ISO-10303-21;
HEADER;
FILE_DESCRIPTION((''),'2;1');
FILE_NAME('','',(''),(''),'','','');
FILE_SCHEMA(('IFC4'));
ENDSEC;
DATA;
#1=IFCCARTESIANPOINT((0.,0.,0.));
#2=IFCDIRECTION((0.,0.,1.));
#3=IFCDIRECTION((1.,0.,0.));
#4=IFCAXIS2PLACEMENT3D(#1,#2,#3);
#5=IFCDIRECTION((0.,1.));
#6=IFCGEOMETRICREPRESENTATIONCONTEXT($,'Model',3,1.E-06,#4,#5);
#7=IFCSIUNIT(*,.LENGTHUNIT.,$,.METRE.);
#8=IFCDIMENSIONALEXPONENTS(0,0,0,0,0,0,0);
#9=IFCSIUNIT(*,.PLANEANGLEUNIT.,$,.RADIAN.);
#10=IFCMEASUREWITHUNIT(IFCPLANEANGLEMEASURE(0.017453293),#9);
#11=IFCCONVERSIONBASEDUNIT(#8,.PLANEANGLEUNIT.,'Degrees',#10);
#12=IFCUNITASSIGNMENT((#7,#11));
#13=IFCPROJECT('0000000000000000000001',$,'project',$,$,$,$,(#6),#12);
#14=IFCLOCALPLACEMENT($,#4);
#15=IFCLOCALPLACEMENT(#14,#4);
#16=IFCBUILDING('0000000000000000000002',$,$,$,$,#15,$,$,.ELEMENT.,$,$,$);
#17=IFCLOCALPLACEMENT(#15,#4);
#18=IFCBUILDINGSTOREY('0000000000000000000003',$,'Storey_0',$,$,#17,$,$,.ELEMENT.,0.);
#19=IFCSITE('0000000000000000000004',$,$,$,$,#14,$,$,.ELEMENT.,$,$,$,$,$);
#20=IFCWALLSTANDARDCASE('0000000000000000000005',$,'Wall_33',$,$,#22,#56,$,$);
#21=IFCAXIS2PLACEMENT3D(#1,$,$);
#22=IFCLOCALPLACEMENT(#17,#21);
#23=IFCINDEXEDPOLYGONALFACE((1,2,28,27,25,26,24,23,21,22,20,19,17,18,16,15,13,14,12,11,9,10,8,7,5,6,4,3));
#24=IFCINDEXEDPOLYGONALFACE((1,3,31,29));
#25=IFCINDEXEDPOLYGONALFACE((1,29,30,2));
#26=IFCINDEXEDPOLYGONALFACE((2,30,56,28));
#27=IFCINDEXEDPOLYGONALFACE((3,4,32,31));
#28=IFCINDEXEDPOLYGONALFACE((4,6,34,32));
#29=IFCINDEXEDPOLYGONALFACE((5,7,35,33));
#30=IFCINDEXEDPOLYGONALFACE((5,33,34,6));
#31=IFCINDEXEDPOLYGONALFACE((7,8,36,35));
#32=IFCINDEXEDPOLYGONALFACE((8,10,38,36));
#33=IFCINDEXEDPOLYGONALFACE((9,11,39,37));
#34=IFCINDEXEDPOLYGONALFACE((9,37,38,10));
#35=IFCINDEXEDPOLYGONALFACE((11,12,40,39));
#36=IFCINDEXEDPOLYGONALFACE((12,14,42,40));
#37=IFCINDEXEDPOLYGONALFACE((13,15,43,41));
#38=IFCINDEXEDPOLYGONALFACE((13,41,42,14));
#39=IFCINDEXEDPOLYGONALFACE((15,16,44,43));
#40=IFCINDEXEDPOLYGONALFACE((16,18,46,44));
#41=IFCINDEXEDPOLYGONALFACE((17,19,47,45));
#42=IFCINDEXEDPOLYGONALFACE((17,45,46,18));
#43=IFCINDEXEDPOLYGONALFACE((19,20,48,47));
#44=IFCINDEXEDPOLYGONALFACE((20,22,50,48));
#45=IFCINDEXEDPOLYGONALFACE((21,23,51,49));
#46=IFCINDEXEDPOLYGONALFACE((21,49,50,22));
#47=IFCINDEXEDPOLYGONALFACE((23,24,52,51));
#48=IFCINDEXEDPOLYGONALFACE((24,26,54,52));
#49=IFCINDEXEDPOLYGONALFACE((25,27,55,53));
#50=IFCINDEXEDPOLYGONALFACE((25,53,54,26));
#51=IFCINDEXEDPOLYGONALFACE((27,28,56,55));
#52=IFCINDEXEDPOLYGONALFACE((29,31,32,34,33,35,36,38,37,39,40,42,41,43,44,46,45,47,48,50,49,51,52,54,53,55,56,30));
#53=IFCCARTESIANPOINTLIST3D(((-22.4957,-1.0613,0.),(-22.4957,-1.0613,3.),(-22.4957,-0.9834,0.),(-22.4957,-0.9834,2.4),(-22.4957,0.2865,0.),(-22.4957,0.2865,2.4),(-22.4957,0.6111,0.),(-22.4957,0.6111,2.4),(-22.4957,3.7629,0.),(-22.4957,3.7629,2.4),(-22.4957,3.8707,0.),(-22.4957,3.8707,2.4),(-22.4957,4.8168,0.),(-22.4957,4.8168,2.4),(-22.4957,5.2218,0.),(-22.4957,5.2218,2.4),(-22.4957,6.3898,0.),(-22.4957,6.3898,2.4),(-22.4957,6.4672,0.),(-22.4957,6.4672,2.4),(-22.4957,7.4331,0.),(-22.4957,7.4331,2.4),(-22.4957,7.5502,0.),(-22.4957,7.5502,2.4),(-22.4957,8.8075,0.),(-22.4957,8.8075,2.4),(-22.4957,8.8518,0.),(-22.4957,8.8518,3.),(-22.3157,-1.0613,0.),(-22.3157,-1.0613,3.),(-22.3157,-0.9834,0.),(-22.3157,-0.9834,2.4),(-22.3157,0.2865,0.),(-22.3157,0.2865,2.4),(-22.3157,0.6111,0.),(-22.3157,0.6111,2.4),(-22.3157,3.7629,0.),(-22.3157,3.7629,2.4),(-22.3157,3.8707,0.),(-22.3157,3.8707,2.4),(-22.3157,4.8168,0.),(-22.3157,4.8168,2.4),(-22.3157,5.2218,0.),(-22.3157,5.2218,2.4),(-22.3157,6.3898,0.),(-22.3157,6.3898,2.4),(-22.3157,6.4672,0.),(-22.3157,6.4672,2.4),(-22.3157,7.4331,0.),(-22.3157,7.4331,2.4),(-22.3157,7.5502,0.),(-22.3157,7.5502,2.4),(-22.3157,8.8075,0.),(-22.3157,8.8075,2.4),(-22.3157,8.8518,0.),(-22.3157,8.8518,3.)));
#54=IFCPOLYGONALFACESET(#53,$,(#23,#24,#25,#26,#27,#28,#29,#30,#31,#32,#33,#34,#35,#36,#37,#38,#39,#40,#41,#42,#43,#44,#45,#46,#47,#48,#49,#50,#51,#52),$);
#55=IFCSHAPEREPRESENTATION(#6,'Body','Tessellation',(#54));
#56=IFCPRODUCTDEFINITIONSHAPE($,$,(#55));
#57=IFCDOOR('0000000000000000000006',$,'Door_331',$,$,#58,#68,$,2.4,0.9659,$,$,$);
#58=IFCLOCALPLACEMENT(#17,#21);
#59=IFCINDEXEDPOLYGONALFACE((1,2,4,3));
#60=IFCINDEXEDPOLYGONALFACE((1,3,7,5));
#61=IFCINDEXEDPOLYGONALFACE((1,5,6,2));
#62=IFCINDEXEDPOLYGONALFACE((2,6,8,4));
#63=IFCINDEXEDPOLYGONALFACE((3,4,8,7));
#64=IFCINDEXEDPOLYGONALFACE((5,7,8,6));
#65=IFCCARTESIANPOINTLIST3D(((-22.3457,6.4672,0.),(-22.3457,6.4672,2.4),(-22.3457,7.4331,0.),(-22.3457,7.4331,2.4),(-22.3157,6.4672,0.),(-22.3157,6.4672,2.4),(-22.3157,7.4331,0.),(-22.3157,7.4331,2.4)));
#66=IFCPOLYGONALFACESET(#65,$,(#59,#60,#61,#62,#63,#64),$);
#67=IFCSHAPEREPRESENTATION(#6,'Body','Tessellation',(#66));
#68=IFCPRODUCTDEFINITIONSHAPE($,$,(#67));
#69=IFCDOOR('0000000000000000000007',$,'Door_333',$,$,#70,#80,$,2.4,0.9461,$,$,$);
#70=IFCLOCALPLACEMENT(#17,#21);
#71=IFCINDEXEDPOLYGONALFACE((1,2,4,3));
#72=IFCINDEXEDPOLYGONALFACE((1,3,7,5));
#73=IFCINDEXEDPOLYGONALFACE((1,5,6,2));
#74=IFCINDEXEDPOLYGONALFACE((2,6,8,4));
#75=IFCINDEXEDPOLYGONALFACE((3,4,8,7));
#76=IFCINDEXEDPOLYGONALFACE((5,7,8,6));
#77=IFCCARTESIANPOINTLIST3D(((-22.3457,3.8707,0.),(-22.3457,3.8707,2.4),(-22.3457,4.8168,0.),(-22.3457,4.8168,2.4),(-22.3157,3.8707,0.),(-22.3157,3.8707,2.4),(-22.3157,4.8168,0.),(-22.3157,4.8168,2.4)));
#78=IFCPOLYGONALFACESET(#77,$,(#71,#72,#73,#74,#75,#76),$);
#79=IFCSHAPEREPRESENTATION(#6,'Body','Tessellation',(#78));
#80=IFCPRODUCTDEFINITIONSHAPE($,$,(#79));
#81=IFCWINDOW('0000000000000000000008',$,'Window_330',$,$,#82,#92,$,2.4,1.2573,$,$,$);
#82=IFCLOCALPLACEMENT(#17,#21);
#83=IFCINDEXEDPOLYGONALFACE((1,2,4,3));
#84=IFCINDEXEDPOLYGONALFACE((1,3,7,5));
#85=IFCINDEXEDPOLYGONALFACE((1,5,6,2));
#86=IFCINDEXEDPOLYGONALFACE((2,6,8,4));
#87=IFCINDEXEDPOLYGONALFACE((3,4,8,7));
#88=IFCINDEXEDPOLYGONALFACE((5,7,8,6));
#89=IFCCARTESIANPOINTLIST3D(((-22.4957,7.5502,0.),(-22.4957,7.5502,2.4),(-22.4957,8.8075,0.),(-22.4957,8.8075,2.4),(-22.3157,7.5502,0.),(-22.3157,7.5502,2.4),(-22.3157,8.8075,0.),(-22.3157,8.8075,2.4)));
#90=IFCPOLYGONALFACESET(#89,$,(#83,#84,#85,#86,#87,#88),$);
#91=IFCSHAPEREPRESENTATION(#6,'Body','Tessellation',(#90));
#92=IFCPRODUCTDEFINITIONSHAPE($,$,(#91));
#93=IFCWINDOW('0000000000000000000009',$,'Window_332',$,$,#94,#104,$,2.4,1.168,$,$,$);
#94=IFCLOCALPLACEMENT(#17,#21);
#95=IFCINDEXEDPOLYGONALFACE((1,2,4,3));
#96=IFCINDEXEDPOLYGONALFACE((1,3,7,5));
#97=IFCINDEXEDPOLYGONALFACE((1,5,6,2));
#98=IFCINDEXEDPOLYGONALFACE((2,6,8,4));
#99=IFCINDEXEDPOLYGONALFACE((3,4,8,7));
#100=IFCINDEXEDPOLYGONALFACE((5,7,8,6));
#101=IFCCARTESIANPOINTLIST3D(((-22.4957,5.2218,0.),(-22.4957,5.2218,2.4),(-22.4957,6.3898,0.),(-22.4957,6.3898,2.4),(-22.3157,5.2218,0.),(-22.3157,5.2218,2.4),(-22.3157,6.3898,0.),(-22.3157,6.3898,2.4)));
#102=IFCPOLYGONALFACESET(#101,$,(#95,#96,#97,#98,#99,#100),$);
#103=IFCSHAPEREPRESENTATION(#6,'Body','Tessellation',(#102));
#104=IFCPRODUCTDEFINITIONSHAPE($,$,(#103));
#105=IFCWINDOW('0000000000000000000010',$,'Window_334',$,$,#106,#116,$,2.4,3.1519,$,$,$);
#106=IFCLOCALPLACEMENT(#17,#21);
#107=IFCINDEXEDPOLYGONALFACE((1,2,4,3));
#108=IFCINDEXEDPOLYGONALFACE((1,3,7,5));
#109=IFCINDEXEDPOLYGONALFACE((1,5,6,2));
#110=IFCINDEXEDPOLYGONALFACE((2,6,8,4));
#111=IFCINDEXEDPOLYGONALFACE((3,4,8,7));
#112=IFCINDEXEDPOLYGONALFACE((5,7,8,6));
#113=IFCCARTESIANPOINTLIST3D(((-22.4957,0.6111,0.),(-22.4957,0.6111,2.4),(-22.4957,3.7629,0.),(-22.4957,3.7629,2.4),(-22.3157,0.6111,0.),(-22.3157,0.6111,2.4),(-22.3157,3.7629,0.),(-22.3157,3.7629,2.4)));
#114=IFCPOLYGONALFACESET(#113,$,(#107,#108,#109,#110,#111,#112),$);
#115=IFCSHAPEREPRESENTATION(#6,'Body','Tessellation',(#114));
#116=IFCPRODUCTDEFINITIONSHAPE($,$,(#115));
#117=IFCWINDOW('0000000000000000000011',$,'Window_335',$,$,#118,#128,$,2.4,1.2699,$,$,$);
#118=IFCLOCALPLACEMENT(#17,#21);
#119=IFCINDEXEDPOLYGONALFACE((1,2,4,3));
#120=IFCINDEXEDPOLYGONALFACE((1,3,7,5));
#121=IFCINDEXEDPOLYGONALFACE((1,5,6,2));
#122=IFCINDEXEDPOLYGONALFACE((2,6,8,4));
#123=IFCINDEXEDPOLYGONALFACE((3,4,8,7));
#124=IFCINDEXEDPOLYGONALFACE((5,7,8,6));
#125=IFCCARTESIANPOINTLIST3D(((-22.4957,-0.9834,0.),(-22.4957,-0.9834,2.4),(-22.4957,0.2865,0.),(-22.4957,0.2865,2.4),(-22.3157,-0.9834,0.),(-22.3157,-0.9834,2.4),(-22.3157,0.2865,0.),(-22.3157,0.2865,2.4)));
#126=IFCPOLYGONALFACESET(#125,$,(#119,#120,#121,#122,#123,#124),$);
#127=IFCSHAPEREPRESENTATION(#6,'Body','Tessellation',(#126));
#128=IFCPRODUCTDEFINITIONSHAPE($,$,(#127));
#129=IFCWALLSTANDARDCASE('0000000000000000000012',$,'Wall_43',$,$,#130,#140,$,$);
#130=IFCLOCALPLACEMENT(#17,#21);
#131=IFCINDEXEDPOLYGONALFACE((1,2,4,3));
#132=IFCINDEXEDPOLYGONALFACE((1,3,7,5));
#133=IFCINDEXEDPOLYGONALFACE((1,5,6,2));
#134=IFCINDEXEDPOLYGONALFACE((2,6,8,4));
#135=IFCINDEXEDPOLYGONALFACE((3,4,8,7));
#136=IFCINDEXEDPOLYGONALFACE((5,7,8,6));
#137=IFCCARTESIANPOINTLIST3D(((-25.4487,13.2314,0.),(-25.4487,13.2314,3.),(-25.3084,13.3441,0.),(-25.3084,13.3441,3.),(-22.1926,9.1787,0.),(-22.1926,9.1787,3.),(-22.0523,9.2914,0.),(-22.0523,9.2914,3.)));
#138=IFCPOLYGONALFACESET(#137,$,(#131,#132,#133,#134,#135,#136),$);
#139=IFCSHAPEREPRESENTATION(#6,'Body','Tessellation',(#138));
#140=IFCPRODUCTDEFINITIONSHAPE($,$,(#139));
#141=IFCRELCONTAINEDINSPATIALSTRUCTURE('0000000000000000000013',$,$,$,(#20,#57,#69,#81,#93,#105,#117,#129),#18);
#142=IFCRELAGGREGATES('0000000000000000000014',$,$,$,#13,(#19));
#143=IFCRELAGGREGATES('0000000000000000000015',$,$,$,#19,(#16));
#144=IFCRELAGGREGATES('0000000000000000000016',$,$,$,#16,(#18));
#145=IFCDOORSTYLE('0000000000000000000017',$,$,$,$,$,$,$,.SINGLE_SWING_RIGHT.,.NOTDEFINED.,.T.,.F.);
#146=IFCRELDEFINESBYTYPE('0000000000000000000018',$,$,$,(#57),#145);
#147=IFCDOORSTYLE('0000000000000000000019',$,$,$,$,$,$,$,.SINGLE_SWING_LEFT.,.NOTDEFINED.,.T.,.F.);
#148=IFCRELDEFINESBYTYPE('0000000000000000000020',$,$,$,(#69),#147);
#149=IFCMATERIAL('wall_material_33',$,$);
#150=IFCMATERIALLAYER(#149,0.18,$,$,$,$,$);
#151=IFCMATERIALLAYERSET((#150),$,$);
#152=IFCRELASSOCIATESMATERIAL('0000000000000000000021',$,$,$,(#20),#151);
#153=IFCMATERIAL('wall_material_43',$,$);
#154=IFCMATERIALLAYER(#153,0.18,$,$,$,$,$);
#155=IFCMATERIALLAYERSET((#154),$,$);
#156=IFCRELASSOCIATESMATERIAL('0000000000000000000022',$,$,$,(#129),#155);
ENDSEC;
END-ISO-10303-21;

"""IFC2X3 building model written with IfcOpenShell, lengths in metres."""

from ifc_helpers import new_model, entity, si_unit, converted_unit, direction, frame, frame_2d, origin_with_axes, place, context, project, spatial, polyline, rectangle, outline, extrude, material, layer, layer_set, layer_usage, type_object, element, fill, save


model = new_model("IFC2X3")

# Units and contexts
model_context = context("Model", 3, precision=1e-06, world=origin_with_axes(), true_north=direction((0.0, 1.0)))
ifc_project = project(units=[si_unit("LENGTHUNIT", "METRE"), converted_unit("PLANEANGLEUNIT", "Degrees", entity("IfcPlaneAngleMeasure", 0.017453293), si_unit("PLANEANGLEUNIT", "RADIAN"), dimensions=[0, 0, 0, 0, 0, 0, 0])], contexts=[model_context])

# Site, building, storey
site_placement = place(None, origin_with_axes())
site = spatial("IfcSite", under=ifc_project, at=site_placement, CompositionType="ELEMENT")
building_placement = place(site_placement, origin_with_axes())
building = spatial("IfcBuilding", under=site, at=building_placement, CompositionType="ELEMENT")
storey_placement = place(building_placement, origin_with_axes())
storey = spatial("IfcBuildingStorey", under=building, at=storey_placement, Name="Storey_0", CompositionType="ELEMENT", Elevation=0.0)

# Wall, openings, doors, windows
ifc_material_1 = material(Name="wall_material_33")
ifc_layer_1 = layer(ifc_material_1, 0.18)
ifc_layer_set_1 = layer_set([ifc_layer_1])
ifc_layer_usage_1 = layer_usage(ifc_layer_set_1, "AXIS2", "NEGATIVE", 0.0)
wall_1_placement = place(storey_placement, frame((-22.3157, 8.8518, 0.0), z_axis=(0.0, 0.0, 1.0), x_axis=(0.0, -1.0, 0.0)))
wall_1 = element("IfcWallStandardCase", 1, at=wall_1_placement, inside=storey, material=ifc_layer_usage_1, Name="Wall_33", context=model_context, shape_type="SweptSolid", body=[
    extrude(outline(polyline([(0.0, 0.0), (9.913, 0.0), (9.913, -0.18), (0.0, -0.18), (0.0, 0.0)])), origin_with_axes(), (0.0, 0.0, 1.0), 3.0),
])
opening_1_placement = place(wall_1_placement, frame((0.0443, 0.0, 0.0), z_axis=(0.0, 0.0, 1.0), x_axis=(1.0, 0.0, 0.0)))
opening_1 = element("IfcOpeningElement", 2, at=opening_1_placement, cuts=wall_1, context=model_context, shape_type="SweptSolid", body=[
    extrude(rectangle(XDim=1.2573, YDim=2.4, at=frame_2d((1.2, -0.6287), x_axis=(0.0, 1.0))), frame((0.0, 0.01, 0.0), z_axis=(0.0, -1.0, 0.0), x_axis=(0.0, 0.0, 1.0)), (0.0, 0.0, 1.0), 0.2),
])
opening_2_placement = place(wall_1_placement, frame((1.4187, 0.0, 0.0), z_axis=(0.0, 0.0, 1.0), x_axis=(1.0, 0.0, 0.0)))
opening_2 = element("IfcOpeningElement", 3, at=opening_2_placement, cuts=wall_1, context=model_context, shape_type="SweptSolid", body=[
    extrude(rectangle(XDim=0.9659, YDim=2.4, at=frame_2d((1.2, -0.4829), x_axis=(0.0, 1.0))), frame((0.0, 0.01, 0.0), z_axis=(0.0, -1.0, 0.0), x_axis=(0.0, 0.0, 1.0)), (0.0, 0.0, 1.0), 0.2),
])
opening_3_placement = place(wall_1_placement, frame((2.462, 0.0, 0.0), z_axis=(0.0, 0.0, 1.0), x_axis=(1.0, 0.0, 0.0)))
opening_3 = element("IfcOpeningElement", 4, at=opening_3_placement, cuts=wall_1, context=model_context, shape_type="SweptSolid", body=[
    extrude(rectangle(XDim=1.168, YDim=2.4, at=frame_2d((1.2, -0.584), x_axis=(0.0, 1.0))), frame((0.0, 0.01, 0.0), z_axis=(0.0, -1.0, 0.0), x_axis=(0.0, 0.0, 1.0)), (0.0, 0.0, 1.0), 0.2),
])
opening_4_placement = place(wall_1_placement, frame((4.035, 0.0, 0.0), z_axis=(0.0, 0.0, 1.0), x_axis=(1.0, 0.0, 0.0)))
opening_4 = element("IfcOpeningElement", 5, at=opening_4_placement, cuts=wall_1, context=model_context, shape_type="SweptSolid", body=[
    extrude(rectangle(XDim=0.9461, YDim=2.4, at=frame_2d((1.2, -0.4731), x_axis=(0.0, 1.0))), frame((0.0, 0.01, 0.0), z_axis=(0.0, -1.0, 0.0), x_axis=(0.0, 0.0, 1.0)), (0.0, 0.0, 1.0), 0.2),
])
opening_5_placement = place(wall_1_placement, frame((5.0888, 0.0, 0.0), z_axis=(0.0, 0.0, 1.0), x_axis=(1.0, 0.0, 0.0)))
opening_5 = element("IfcOpeningElement", 6, at=opening_5_placement, cuts=wall_1, context=model_context, shape_type="SweptSolid", body=[
    extrude(rectangle(XDim=3.1519, YDim=2.4, at=frame_2d((1.2, -1.5759), x_axis=(0.0, 1.0))), frame((0.0, 0.01, 0.0), z_axis=(0.0, -1.0, 0.0), x_axis=(0.0, 0.0, 1.0)), (0.0, 0.0, 1.0), 0.2),
])
opening_6_placement = place(wall_1_placement, frame((8.5652, 0.0, 0.0), z_axis=(0.0, 0.0, 1.0), x_axis=(1.0, 0.0, 0.0)))
opening_6 = element("IfcOpeningElement", 7, at=opening_6_placement, cuts=wall_1, context=model_context, shape_type="SweptSolid", body=[
    extrude(rectangle(XDim=1.2699, YDim=2.4, at=frame_2d((1.2, -0.6349), x_axis=(0.0, 1.0))), frame((0.0, 0.01, 0.0), z_axis=(0.0, -1.0, 0.0), x_axis=(0.0, 0.0, 1.0)), (0.0, 0.0, 1.0), 0.2),
])
door_style_1 = type_object("IfcDoorStyle", ConstructionType="NOTDEFINED", OperationType="SINGLE_SWING_RIGHT", ParameterTakesPrecedence=True, Sizeable=False)
door_1_placement = place(storey_placement, origin_with_axes())
door_1 = element("IfcDoor", 8, at=door_1_placement, inside=storey, type_object=door_style_1, Name="Door_331", OverallHeight=2.4, OverallWidth=0.9659, context=model_context, shape_type="SweptSolid", body=[
    extrude(outline(polyline([(-22.3157, 7.4331), (-22.3157, 6.4672), (-22.3457, 6.4672), (-22.3457, 7.4331), (-22.3157, 7.4331)])), origin_with_axes(), (0.0, 0.0, 1.0), 2.4),
])
fill(opening_2, door_1)
door_style_2 = type_object("IfcDoorStyle", ConstructionType="NOTDEFINED", OperationType="SINGLE_SWING_LEFT", ParameterTakesPrecedence=True, Sizeable=False)
door_2_placement = place(storey_placement, origin_with_axes())
door_2 = element("IfcDoor", 9, at=door_2_placement, inside=storey, type_object=door_style_2, Name="Door_333", OverallHeight=2.4, OverallWidth=0.9461, context=model_context, shape_type="SweptSolid", body=[
    extrude(outline(polyline([(-22.3157, 4.8168), (-22.3157, 3.8707), (-22.3457, 3.8707), (-22.3457, 4.8168), (-22.3157, 4.8168)])), origin_with_axes(), (0.0, 0.0, 1.0), 2.4),
])
fill(opening_4, door_2)
window_1_placement = place(storey_placement, origin_with_axes())
window_1 = element("IfcWindow", 10, at=window_1_placement, inside=storey, Name="Window_330", OverallHeight=2.4, OverallWidth=1.2573, context=model_context, shape_type="SweptSolid", body=[
    extrude(outline(polyline([(-22.3157, 8.8075), (-22.3157, 7.5502), (-22.4957, 7.5502), (-22.4957, 8.8075), (-22.3157, 8.8075)])), origin_with_axes(), (0.0, 0.0, 1.0), 2.4),
])
fill(opening_1, window_1)
window_2_placement = place(storey_placement, origin_with_axes())
window_2 = element("IfcWindow", 11, at=window_2_placement, inside=storey, Name="Window_332", OverallHeight=2.4, OverallWidth=1.168, context=model_context, shape_type="SweptSolid", body=[
    extrude(outline(polyline([(-22.3157, 6.3898), (-22.3157, 5.2218), (-22.4957, 5.2218), (-22.4957, 6.3898), (-22.3157, 6.3898)])), origin_with_axes(), (0.0, 0.0, 1.0), 2.4),
])
fill(opening_3, window_2)
window_3_placement = place(storey_placement, origin_with_axes())
window_3 = element("IfcWindow", 12, at=window_3_placement, inside=storey, Name="Window_334", OverallHeight=2.4, OverallWidth=3.1519, context=model_context, shape_type="SweptSolid", body=[
    extrude(outline(polyline([(-22.3157, 3.7629), (-22.3157, 0.6111), (-22.4957, 0.6111), (-22.4957, 3.7629), (-22.3157, 3.7629)])), origin_with_axes(), (0.0, 0.0, 1.0), 2.4),
])
fill(opening_5, window_3)
window_4_placement = place(storey_placement, origin_with_axes())
window_4 = element("IfcWindow", 13, at=window_4_placement, inside=storey, Name="Window_335", OverallHeight=2.4, OverallWidth=1.2699, context=model_context, shape_type="SweptSolid", body=[
    extrude(outline(polyline([(-22.3157, 0.2865), (-22.3157, -0.9834), (-22.4957, -0.9834), (-22.4957, 0.2865), (-22.3157, 0.2865)])), origin_with_axes(), (0.0, 0.0, 1.0), 2.4),
])
fill(opening_6, window_4)

# Wall
ifc_material_2 = material(Name="wall_material_43")
ifc_layer_2 = layer(ifc_material_2, 0.18)
ifc_layer_set_2 = layer_set([ifc_layer_2])
ifc_layer_usage_2 = layer_usage(ifc_layer_set_2, "AXIS2", "NEGATIVE", 0.0)
wall_2_placement = place(storey_placement, frame((-25.3084, 13.3441, 0.0), z_axis=(0.0, 0.0, 1.0), x_axis=(0.626332, -0.779557, 0.0)))
element("IfcWallStandardCase", 14, at=wall_2_placement, inside=storey, material=ifc_layer_usage_2, Name="Wall_43", context=model_context, shape_type="SweptSolid", body=[
    extrude(outline(polyline([(0.0, 0.0), (5.1987, 0.0), (5.1987, -0.18), (0.0, -0.18), (0.0, 0.0)])), origin_with_axes(), (0.0, 0.0, 1.0), 3.0),
])

save(model, "model.ifc")
